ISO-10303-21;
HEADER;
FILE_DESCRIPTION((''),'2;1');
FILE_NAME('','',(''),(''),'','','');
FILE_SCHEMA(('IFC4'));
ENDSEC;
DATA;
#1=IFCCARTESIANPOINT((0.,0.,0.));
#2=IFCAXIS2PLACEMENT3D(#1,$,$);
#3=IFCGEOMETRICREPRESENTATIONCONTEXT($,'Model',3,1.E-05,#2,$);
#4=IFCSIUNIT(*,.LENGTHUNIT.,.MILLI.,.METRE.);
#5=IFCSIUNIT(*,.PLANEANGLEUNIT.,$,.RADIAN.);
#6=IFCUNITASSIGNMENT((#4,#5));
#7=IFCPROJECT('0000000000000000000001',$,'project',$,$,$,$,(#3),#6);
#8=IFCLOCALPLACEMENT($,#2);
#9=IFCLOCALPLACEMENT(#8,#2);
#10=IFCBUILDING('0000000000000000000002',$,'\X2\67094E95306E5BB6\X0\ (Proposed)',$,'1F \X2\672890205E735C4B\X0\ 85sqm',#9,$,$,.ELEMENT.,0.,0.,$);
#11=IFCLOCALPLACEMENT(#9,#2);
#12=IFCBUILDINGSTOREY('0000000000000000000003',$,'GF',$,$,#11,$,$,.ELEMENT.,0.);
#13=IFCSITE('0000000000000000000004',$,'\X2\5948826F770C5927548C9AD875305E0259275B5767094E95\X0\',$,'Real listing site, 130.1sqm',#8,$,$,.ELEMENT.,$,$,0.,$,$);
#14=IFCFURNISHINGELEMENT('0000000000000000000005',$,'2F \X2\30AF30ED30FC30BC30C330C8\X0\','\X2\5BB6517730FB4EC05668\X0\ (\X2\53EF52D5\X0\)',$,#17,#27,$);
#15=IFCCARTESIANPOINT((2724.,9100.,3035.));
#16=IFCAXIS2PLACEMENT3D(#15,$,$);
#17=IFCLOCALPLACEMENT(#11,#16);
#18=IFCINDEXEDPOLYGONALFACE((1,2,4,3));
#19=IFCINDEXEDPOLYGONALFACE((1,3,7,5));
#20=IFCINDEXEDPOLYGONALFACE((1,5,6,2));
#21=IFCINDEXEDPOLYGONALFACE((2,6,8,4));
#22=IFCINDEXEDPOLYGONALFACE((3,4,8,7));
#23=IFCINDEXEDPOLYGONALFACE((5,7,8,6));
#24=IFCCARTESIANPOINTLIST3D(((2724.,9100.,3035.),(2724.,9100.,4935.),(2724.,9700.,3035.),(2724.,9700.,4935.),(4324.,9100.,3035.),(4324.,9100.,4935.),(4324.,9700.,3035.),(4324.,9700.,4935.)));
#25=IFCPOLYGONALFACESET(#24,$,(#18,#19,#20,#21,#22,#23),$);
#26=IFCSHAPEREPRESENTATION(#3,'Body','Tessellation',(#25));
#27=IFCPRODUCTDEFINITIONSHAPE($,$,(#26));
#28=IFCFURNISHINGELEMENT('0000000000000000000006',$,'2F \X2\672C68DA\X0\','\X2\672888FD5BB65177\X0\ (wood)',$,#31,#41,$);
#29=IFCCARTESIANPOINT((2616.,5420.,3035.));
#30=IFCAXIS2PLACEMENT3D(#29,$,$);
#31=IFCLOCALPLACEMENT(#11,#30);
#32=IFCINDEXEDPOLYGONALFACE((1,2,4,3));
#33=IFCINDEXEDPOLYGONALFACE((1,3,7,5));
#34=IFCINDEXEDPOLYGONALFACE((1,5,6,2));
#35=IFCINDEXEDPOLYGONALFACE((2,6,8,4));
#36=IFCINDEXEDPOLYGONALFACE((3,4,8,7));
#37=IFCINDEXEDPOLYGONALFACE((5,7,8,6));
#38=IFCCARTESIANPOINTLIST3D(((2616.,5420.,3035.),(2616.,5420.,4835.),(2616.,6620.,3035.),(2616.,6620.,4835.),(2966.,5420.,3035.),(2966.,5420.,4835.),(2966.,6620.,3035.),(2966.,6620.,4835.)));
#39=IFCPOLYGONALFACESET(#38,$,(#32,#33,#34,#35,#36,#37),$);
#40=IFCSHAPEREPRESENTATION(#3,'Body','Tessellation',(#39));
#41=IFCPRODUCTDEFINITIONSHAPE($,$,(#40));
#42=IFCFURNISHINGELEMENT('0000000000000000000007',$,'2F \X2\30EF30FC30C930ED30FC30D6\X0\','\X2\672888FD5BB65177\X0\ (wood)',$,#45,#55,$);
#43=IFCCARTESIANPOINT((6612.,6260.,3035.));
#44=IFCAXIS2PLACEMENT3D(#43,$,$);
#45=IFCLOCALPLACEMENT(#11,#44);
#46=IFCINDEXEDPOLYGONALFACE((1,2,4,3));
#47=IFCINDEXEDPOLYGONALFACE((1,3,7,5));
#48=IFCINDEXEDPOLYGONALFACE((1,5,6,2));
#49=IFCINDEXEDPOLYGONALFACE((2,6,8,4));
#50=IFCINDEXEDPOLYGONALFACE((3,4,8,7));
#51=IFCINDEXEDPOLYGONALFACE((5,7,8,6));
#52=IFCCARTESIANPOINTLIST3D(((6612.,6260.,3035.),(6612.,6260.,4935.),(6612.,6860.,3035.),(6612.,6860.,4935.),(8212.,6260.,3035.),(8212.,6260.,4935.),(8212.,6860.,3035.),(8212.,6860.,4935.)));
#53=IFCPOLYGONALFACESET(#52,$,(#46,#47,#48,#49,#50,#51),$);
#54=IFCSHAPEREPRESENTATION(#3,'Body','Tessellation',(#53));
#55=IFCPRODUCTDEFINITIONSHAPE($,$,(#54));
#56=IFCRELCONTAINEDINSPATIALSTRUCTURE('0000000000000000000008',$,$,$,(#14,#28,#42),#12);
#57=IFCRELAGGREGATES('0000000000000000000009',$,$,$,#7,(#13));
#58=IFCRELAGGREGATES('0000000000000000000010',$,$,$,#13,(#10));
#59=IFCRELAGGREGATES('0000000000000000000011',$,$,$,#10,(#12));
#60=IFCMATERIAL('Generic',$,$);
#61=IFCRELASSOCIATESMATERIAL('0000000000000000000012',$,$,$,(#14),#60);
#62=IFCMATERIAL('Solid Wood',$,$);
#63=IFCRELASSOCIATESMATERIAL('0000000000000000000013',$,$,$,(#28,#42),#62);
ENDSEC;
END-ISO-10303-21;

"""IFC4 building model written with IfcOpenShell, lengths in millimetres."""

from ifc_helpers import new_model, si_unit, frame, frame_2d, origin, place, context, project, spatial, rectangle, extrude, material, element, save


model = new_model("IFC4")

# Units and contexts
model_context = context("Model", 3, precision=1e-05, world=origin())
ifc_project = project(units=[si_unit("LENGTHUNIT", "METRE", prefix="MILLI"), si_unit("PLANEANGLEUNIT", "RADIAN")], contexts=[model_context])

# Site, building, storey
site_placement = place(None, origin())
site = spatial("IfcSite", under=ifc_project, at=site_placement, Name="奈良県大和高田市大字有井", ObjectType="Real listing site, 130.1sqm", CompositionType="ELEMENT", RefElevation=0.0)
building_placement = place(site_placement, origin())
building = spatial("IfcBuilding", under=site, at=building_placement, Name="有井の家 (Proposed)", ObjectType="1F 木造平屋 85sqm", CompositionType="ELEMENT", ElevationOfRefHeight=0.0, ElevationOfTerrain=0.0)
storey_placement = place(building_placement, origin())
storey = spatial("IfcBuildingStorey", under=building, at=storey_placement, Name="GF", CompositionType="ELEMENT", Elevation=0.0)

# Shared definitions
ifc_material_1 = material(Name="Solid Wood")

# Shared definitions
ifc_material_2 = material(Name="Generic")

# Furnishing elements
furnishing_1_placement = place(storey_placement, frame((2724.0, 9100.0, 3035.0)))
element("IfcFurnishingElement", 1, at=furnishing_1_placement, inside=storey, material=ifc_material_2, Name="2F クローゼット", Description="家具・什器 (可動)", context=model_context, shape_type="SweptSolid", body=[
    extrude(rectangle(XDim=1600.0, YDim=600.0, at=frame_2d((800.0, 300.0))), frame((2724.0, 9100.0, 3035.0)), (0.0, 0.0, 1.0), 1900.0),
])
furnishing_2_placement = place(storey_placement, frame((2616.0, 5420.0, 3035.0)))
element("IfcFurnishingElement", 2, at=furnishing_2_placement, inside=storey, material=ifc_material_1, Name="2F 本棚", Description="木製家具 (wood)", context=model_context, shape_type="SweptSolid", body=[
    extrude(rectangle(XDim=350.0, YDim=1200.0, at=frame_2d((175.0, 600.0))), frame((2616.0, 5420.0, 3035.0)), (0.0, 0.0, 1.0), 1800.0),
])
furnishing_3_placement = place(storey_placement, frame((6612.0, 6260.0, 3035.0)))
element("IfcFurnishingElement", 3, at=furnishing_3_placement, inside=storey, material=ifc_material_1, Name="2F ワードローブ", Description="木製家具 (wood)", context=model_context, shape_type="SweptSolid", body=[
    extrude(rectangle(XDim=1600.0, YDim=600.0, at=frame_2d((800.0, 300.0))), frame((6612.0, 6260.0, 3035.0)), (0.0, 0.0, 1.0), 1900.0),
])

save(model, "model.ifc")
